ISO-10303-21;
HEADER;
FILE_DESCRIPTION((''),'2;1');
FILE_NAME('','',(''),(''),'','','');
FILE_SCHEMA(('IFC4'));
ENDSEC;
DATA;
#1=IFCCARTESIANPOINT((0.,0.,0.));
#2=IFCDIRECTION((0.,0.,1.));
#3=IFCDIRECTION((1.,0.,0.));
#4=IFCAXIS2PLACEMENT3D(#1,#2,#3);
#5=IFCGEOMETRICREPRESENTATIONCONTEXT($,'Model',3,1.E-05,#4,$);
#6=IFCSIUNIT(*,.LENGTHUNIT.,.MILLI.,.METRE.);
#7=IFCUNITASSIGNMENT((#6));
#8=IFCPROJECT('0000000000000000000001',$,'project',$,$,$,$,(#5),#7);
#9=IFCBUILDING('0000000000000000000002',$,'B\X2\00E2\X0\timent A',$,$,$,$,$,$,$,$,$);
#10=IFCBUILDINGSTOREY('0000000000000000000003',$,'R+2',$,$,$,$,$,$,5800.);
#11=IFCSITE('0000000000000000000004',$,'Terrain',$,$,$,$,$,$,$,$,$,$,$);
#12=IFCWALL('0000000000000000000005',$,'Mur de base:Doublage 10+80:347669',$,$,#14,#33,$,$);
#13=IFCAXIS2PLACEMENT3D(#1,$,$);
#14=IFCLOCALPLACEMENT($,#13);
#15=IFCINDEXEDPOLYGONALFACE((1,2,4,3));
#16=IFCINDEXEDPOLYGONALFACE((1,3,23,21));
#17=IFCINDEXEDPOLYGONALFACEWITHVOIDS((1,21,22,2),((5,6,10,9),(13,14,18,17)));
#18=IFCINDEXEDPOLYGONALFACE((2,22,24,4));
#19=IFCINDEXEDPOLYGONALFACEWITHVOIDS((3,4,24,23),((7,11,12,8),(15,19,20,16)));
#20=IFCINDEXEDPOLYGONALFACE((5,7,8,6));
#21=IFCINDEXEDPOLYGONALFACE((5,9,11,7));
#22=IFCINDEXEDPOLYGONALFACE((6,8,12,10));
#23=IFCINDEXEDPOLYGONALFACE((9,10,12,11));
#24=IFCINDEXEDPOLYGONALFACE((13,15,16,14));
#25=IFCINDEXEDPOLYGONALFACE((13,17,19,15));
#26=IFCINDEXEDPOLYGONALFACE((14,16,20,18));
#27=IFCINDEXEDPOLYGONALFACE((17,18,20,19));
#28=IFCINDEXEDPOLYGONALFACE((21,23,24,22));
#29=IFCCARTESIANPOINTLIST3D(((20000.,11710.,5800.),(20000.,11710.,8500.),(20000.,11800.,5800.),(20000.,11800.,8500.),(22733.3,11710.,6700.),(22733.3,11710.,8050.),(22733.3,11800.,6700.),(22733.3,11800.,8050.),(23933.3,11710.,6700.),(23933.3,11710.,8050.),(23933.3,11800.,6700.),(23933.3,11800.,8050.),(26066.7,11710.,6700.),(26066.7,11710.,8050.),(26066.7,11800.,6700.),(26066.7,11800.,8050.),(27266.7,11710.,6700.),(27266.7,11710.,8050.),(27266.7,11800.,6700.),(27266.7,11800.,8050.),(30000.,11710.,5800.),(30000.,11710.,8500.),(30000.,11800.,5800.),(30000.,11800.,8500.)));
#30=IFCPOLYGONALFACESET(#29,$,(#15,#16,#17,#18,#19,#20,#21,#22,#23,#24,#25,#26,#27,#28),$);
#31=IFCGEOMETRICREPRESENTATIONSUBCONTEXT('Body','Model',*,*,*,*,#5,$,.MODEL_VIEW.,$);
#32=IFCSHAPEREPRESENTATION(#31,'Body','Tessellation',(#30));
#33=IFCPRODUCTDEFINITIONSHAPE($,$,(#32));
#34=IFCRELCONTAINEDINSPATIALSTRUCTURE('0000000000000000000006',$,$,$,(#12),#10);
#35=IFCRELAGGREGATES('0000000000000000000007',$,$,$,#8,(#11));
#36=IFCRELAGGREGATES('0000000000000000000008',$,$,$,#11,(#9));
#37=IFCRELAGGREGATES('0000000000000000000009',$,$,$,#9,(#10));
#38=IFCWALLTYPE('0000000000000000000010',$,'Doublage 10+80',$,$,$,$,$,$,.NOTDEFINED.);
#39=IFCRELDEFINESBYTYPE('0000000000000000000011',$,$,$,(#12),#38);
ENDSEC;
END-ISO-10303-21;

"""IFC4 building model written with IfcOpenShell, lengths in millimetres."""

from ifc_helpers import new_model, si_unit, frame, frame_2d, origin_with_axes, place, context, subcontext, project, spatial, rectangle, extrude, type_object, element, save


model = new_model("IFC4")

# Units and contexts
model_context = context("Model", 3, precision=1e-05, world=origin_with_axes())
body_context = subcontext(model_context, "Body", "Model", "MODEL_VIEW")
ifc_project = project(units=[si_unit("LENGTHUNIT", "METRE", prefix="MILLI")], contexts=[model_context])

# Site, building, storey
site = spatial("IfcSite", under=ifc_project, Name="Terrain")
building = spatial("IfcBuilding", under=site, Name="Bâtiment A")
storey = spatial("IfcBuildingStorey", under=building, Name="R+2", Elevation=5800.0)

# Wall, openings
wall_type_1 = type_object("IfcWallType", Name="Doublage 10+80", PredefinedType="NOTDEFINED")
wall_1_placement = place(None, origin_with_axes())
wall_1 = element("IfcWall", 1, at=wall_1_placement, inside=storey, type_object=wall_type_1, Name="Mur de base:Doublage 10+80:347669", context=body_context, shape_type="SweptSolid", body=[
    extrude(rectangle(XDim=10000.0, YDim=90.0, at=frame_2d((25000.0, 11755.0))), frame((0.0, 0.0, 5800.0), z_axis=(0.0, 0.0, 1.0), x_axis=(1.0, 0.0, 0.0)), (0.0, 0.0, 1.0), 2700.0),
])
opening_1_placement = place(None, origin_with_axes())
element("IfcOpeningElement", 2, at=opening_1_placement, cuts=wall_1, context=body_context, shape_type="SweptSolid", body=[
    extrude(rectangle(XDim=1200.0, YDim=210.0, at=frame_2d((23333.3, 11755.0))), frame((0.0, 0.0, 6700.0), z_axis=(0.0, 0.0, 1.0), x_axis=(1.0, 0.0, 0.0)), (0.0, 0.0, 1.0), 1350.0),
])
opening_2_placement = place(None, origin_with_axes())
element("IfcOpeningElement", 3, at=opening_2_placement, cuts=wall_1, context=body_context, shape_type="SweptSolid", body=[
    extrude(rectangle(XDim=1200.0, YDim=210.0, at=frame_2d((26666.7, 11755.0))), frame((0.0, 0.0, 6700.0), z_axis=(0.0, 0.0, 1.0), x_axis=(1.0, 0.0, 0.0)), (0.0, 0.0, 1.0), 1350.0),
])

save(model, "model.ifc")
